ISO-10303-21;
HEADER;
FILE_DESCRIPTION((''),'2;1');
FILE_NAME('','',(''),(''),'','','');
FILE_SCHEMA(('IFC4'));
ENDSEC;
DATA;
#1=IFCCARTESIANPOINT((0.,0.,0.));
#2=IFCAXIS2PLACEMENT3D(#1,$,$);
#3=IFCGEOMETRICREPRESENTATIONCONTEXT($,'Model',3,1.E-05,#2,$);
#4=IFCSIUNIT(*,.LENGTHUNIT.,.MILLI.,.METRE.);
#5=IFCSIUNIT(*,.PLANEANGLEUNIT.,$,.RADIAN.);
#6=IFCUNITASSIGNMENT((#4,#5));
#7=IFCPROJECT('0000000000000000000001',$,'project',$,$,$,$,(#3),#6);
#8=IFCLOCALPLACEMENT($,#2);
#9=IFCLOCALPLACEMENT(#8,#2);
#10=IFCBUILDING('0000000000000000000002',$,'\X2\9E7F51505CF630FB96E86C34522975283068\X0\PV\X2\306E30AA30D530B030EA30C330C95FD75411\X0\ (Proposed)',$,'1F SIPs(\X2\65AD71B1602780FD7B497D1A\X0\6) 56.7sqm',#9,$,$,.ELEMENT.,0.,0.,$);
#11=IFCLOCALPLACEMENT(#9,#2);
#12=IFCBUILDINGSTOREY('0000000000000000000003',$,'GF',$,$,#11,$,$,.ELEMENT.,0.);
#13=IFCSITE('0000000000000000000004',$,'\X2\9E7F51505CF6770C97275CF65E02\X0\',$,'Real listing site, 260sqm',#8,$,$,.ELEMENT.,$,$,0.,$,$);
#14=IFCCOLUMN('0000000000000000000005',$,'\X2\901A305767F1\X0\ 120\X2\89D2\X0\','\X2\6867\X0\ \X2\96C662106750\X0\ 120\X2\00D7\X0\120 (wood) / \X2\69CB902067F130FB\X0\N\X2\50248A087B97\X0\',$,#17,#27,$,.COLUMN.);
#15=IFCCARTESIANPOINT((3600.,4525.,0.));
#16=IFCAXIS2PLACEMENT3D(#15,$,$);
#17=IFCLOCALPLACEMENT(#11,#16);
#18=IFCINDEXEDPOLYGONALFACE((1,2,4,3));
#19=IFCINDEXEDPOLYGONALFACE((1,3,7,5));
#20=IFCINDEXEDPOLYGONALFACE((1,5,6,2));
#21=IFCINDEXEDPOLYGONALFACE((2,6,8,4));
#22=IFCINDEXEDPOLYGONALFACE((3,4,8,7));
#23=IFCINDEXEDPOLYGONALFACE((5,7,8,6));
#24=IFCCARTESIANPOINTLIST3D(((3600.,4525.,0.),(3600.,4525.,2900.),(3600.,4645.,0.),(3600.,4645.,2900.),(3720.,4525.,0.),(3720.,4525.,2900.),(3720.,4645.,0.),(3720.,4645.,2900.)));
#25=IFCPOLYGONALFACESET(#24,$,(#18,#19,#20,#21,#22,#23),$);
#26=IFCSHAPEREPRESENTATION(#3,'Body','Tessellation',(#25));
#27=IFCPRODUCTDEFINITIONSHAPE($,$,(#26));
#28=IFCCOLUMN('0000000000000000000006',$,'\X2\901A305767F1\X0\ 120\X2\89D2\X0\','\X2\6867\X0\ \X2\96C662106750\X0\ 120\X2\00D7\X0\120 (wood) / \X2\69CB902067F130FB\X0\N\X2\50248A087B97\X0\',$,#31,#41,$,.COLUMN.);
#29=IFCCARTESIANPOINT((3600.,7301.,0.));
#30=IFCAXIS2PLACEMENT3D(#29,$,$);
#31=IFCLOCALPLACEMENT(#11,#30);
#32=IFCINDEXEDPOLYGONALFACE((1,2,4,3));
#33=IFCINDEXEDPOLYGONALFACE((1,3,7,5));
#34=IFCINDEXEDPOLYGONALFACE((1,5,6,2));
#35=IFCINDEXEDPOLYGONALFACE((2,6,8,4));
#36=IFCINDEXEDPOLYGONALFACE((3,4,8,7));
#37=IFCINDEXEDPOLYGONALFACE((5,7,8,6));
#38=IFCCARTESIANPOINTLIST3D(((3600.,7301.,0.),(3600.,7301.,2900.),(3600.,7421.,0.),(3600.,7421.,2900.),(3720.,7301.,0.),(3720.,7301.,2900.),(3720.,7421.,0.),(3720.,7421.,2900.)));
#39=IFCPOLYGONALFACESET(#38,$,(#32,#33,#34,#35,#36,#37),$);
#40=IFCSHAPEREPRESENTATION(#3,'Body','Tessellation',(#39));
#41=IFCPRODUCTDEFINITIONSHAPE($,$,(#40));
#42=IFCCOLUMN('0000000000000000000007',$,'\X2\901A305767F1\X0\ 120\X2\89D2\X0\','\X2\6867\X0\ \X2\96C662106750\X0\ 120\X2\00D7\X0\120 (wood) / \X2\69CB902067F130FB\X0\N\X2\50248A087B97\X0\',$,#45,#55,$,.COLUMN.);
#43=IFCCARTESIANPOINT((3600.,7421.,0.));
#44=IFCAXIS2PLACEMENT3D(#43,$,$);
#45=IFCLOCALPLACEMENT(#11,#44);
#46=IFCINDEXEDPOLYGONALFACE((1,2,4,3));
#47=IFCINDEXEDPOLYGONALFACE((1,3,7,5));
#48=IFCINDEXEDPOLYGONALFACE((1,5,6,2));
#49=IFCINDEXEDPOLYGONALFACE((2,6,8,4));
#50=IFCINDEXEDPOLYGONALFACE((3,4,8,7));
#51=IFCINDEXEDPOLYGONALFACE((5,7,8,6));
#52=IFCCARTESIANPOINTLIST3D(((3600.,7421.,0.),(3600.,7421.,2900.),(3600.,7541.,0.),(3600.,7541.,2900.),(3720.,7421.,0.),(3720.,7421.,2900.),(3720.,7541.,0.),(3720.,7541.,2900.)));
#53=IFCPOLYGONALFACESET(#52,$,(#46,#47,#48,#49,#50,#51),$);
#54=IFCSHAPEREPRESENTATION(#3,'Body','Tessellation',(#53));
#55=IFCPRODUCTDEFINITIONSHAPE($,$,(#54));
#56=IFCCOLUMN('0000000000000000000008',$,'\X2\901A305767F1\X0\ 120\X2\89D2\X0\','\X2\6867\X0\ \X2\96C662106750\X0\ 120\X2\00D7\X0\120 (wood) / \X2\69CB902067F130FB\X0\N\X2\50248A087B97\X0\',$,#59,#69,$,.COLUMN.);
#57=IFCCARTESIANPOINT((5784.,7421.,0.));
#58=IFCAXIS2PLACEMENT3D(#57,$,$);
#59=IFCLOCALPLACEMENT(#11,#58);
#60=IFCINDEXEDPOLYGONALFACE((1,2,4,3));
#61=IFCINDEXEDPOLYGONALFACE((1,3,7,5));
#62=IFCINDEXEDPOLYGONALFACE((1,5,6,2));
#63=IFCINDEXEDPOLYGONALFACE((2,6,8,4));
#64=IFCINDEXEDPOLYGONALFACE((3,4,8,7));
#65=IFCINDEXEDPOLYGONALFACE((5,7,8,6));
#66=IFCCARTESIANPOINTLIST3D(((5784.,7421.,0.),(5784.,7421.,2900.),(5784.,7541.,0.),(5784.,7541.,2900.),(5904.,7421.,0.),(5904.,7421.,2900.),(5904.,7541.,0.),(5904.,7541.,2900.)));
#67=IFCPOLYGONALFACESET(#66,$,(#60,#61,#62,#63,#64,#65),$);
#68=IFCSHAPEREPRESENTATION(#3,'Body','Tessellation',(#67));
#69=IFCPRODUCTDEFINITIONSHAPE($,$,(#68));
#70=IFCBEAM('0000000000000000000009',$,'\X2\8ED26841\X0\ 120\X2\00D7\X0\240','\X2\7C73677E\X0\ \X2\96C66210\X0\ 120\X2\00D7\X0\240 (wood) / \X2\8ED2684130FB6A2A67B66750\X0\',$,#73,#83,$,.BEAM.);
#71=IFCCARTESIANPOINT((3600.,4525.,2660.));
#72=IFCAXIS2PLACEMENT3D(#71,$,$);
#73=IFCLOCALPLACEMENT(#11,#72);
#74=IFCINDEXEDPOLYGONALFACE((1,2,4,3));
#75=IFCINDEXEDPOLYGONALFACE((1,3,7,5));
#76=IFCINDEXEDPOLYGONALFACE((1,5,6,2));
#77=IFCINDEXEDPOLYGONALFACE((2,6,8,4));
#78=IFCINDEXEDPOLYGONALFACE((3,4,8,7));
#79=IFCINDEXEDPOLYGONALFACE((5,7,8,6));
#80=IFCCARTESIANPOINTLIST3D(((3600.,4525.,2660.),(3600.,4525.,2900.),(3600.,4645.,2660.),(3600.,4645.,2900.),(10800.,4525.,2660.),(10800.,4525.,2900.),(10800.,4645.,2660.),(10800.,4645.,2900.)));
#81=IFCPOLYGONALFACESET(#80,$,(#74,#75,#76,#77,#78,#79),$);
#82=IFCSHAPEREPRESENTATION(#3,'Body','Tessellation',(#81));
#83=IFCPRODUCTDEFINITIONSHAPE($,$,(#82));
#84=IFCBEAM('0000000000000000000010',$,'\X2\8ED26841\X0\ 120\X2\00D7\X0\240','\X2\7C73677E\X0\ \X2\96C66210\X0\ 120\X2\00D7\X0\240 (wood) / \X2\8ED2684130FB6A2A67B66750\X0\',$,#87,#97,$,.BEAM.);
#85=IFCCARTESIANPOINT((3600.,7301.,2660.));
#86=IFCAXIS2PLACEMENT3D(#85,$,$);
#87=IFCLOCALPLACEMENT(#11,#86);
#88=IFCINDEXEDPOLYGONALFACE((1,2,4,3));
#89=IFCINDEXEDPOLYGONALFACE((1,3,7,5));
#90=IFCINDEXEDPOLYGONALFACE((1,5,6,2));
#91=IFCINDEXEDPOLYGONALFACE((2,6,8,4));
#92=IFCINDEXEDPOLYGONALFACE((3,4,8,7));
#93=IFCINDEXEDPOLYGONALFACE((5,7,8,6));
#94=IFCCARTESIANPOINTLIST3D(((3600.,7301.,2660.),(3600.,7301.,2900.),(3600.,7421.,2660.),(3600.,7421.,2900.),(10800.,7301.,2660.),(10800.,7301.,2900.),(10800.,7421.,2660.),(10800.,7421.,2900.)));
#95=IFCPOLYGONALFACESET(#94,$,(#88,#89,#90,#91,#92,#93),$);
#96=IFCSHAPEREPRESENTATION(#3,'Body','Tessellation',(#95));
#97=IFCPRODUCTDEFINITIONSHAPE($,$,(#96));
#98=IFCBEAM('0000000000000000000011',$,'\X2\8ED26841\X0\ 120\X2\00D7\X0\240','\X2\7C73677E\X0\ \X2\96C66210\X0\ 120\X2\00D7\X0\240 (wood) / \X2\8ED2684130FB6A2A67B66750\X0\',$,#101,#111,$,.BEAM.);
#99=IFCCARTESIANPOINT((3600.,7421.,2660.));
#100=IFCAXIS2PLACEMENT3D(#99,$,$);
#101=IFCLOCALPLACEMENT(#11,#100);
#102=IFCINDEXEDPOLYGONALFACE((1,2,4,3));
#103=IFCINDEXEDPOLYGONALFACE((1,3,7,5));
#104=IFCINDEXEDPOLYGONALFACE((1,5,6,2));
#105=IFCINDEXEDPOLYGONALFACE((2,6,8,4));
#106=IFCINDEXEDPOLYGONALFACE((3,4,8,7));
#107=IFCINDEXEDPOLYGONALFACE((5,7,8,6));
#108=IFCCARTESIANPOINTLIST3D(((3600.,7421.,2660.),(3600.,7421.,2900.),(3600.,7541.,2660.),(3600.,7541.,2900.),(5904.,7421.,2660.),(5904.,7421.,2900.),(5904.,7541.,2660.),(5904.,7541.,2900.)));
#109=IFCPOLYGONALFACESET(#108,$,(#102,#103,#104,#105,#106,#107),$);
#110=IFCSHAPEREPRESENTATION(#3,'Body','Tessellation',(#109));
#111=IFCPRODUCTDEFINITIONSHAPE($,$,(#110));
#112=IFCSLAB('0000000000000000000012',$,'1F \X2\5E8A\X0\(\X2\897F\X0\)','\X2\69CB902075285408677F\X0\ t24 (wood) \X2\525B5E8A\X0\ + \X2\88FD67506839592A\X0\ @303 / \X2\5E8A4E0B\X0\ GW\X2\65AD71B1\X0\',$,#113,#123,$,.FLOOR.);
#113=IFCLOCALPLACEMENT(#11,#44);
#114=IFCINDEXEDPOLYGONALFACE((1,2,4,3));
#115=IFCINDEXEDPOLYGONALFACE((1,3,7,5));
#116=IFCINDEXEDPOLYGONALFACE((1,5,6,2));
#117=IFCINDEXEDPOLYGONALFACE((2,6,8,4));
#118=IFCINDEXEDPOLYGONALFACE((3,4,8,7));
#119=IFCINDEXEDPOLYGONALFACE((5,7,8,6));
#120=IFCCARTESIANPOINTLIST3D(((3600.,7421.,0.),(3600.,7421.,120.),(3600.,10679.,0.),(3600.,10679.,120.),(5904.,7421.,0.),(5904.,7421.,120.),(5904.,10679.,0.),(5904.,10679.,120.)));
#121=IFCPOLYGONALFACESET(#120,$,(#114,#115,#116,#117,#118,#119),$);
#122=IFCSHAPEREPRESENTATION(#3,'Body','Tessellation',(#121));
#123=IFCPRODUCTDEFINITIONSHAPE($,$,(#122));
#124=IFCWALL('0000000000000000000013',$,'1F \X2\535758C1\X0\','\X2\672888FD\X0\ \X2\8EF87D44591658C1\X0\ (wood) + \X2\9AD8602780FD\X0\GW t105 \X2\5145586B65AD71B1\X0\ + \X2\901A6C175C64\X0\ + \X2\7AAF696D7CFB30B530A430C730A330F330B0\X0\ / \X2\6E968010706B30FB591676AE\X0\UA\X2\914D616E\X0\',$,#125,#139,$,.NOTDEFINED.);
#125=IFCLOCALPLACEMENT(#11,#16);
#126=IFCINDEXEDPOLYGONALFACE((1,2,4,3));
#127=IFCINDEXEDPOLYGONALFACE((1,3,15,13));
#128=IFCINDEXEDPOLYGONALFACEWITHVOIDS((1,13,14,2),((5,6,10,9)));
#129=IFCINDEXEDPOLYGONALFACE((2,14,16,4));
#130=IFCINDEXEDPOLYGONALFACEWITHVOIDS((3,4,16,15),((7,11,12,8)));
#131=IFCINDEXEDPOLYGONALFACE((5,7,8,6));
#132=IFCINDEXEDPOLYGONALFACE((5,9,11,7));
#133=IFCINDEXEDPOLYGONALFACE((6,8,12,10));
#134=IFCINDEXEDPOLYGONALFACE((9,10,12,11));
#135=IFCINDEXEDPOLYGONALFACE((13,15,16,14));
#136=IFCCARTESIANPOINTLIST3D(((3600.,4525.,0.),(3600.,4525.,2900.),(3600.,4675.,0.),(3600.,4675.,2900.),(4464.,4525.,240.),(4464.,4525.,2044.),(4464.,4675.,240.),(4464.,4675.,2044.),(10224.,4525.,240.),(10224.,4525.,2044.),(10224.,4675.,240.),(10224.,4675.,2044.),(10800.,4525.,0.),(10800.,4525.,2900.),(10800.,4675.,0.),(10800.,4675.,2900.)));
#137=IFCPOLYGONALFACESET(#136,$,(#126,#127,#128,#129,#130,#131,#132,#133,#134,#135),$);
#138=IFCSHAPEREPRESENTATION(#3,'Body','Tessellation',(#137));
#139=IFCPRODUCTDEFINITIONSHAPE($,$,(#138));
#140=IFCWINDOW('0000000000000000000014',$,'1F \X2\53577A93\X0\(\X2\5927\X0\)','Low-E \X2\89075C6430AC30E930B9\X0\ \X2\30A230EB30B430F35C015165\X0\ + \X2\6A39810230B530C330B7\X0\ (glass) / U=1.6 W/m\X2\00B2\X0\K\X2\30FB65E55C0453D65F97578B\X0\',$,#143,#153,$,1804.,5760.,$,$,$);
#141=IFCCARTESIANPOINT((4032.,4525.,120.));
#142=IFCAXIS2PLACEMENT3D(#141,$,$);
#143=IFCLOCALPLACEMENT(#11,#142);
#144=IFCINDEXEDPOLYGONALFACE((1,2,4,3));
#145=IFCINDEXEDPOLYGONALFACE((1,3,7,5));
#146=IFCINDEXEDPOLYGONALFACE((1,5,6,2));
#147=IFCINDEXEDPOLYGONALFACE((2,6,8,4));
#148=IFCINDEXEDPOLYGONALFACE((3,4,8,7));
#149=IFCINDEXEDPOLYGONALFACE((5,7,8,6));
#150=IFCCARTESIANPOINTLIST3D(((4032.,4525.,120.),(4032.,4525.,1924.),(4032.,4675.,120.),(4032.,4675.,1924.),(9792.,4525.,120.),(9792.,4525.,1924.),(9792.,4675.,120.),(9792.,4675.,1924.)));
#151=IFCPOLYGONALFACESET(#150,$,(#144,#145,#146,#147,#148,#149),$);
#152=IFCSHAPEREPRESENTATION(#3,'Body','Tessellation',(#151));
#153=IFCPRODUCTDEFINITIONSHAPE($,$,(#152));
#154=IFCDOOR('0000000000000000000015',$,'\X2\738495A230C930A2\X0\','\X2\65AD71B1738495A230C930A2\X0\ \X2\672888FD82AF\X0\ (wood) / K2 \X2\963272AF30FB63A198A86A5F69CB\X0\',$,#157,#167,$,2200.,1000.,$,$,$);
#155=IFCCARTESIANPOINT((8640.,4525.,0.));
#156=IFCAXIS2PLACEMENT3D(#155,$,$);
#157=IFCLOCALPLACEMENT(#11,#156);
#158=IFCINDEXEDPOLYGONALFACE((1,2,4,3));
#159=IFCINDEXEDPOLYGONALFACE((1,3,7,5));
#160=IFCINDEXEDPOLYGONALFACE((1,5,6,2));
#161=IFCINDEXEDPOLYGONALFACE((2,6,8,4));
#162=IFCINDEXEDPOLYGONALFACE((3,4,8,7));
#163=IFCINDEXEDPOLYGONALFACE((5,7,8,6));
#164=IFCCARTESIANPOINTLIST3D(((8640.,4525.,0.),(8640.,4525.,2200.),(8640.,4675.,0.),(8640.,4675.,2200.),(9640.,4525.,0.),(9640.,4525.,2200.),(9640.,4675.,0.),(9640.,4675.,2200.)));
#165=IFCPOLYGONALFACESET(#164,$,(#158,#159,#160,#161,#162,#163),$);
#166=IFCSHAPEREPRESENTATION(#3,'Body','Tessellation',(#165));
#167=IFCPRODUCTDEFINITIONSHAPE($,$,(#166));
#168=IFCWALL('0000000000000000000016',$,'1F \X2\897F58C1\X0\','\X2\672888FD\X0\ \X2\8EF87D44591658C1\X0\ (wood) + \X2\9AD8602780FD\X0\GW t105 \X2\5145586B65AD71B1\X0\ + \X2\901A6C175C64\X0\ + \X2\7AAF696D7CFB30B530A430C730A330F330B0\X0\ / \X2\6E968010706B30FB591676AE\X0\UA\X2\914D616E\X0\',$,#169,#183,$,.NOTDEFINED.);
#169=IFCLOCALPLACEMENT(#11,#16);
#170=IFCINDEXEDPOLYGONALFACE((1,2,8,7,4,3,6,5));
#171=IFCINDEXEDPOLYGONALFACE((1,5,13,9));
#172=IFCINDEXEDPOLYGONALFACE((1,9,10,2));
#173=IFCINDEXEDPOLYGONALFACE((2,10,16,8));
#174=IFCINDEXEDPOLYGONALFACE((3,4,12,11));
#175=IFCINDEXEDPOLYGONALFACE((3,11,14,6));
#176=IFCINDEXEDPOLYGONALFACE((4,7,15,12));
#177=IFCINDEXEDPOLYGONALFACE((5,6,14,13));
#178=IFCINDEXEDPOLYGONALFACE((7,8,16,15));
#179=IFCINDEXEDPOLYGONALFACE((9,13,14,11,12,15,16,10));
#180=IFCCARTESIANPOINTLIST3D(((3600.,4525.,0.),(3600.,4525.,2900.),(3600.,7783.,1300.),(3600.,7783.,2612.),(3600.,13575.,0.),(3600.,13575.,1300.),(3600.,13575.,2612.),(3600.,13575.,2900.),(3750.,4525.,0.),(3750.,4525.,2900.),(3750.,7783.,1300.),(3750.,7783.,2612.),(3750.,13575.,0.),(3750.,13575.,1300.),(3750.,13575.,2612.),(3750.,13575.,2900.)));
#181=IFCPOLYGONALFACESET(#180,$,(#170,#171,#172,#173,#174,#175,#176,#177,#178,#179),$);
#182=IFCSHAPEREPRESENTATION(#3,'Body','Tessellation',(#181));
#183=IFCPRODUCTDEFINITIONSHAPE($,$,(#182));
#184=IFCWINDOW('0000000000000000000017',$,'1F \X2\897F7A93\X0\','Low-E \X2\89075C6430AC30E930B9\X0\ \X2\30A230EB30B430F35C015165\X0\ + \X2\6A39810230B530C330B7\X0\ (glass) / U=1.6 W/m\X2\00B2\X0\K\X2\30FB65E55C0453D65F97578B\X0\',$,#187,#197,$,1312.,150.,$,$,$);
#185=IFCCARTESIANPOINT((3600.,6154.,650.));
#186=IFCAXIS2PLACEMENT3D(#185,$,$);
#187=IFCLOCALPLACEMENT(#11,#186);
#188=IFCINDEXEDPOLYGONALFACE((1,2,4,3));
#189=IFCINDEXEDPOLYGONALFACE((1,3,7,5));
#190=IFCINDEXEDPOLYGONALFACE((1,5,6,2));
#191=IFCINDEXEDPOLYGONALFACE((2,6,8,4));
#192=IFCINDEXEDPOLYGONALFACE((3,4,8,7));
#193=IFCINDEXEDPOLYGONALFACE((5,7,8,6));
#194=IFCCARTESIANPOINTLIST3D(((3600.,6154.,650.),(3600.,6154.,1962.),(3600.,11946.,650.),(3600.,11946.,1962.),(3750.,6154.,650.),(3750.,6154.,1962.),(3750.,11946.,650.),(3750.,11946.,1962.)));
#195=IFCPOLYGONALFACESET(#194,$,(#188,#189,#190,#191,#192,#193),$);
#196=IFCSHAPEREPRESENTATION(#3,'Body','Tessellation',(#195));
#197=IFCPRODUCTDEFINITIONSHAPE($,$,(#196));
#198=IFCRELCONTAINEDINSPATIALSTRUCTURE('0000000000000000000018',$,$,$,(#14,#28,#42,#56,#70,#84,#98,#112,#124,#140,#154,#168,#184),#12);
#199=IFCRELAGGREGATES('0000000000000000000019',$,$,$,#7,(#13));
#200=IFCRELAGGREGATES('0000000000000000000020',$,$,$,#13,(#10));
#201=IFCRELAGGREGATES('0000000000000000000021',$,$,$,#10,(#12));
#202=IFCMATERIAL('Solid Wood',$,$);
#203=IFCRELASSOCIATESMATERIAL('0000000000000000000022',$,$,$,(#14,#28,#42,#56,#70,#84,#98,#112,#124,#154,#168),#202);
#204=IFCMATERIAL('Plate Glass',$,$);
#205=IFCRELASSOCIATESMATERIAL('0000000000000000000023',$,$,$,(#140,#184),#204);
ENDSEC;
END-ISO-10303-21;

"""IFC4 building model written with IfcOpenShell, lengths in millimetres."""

from ifc_helpers import new_model, si_unit, frame, frame_2d, origin, place, context, project, spatial, rectangle, extrude, material, element, fill, save


model = new_model("IFC4")

# Units and contexts
model_context = context("Model", 3, precision=1e-05, world=origin())
ifc_project = project(units=[si_unit("LENGTHUNIT", "METRE", prefix="MILLI"), si_unit("PLANEANGLEUNIT", "RADIAN")], contexts=[model_context])

# Site, building, storey
site_placement = place(None, origin())
site = spatial("IfcSite", under=ifc_project, at=site_placement, Name="鹿児島県霧島市", ObjectType="Real listing site, 260sqm", CompositionType="ELEMENT", RefElevation=0.0)
building_placement = place(site_placement, origin())
building = spatial("IfcBuilding", under=site, at=building_placement, Name="鹿児島・雨水利用とPVのオフグリッド志向 (Proposed)", ObjectType="1F SIPs(断熱性能等級6) 56.7sqm", CompositionType="ELEMENT", ElevationOfRefHeight=0.0, ElevationOfTerrain=0.0)
storey_placement = place(building_placement, origin())
storey = spatial("IfcBuildingStorey", under=building, at=storey_placement, Name="GF", CompositionType="ELEMENT", Elevation=0.0)

# Columns
ifc_material_1 = material(Name="Solid Wood")
column_1_placement = place(storey_placement, frame((3600.0, 4525.0, 0.0)))
element("IfcColumn", 1, at=column_1_placement, inside=storey, material=ifc_material_1, Name="通し柱 120角", Description="桧 集成材 120×120 (wood) / 構造柱・N値計算", PredefinedType="COLUMN", context=model_context, shape_type="SweptSolid", body=[
    extrude(rectangle(XDim=120.0, YDim=120.0, at=frame_2d((60.0, 60.0))), frame((3600.0, 4525.0, 0.0)), (0.0, 0.0, 1.0), 2900.0),
])
column_2_placement = place(storey_placement, frame((3600.0, 7301.0, 0.0)))
element("IfcColumn", 2, at=column_2_placement, inside=storey, material=ifc_material_1, Name="通し柱 120角", Description="桧 集成材 120×120 (wood) / 構造柱・N値計算", PredefinedType="COLUMN", context=model_context, shape_type="SweptSolid", body=[
    extrude(rectangle(XDim=120.0, YDim=120.0, at=frame_2d((60.0, 60.0))), frame((3600.0, 7301.0, 0.0)), (0.0, 0.0, 1.0), 2900.0),
])
column_3_placement = place(storey_placement, frame((3600.0, 7421.0, 0.0)))
element("IfcColumn", 3, at=column_3_placement, inside=storey, material=ifc_material_1, Name="通し柱 120角", Description="桧 集成材 120×120 (wood) / 構造柱・N値計算", PredefinedType="COLUMN", context=model_context, shape_type="SweptSolid", body=[
    extrude(rectangle(XDim=120.0, YDim=120.0, at=frame_2d((60.0, 60.0))), frame((3600.0, 7421.0, 0.0)), (0.0, 0.0, 1.0), 2900.0),
])
column_4_placement = place(storey_placement, frame((5784.0, 7421.0, 0.0)))
element("IfcColumn", 4, at=column_4_placement, inside=storey, material=ifc_material_1, Name="通し柱 120角", Description="桧 集成材 120×120 (wood) / 構造柱・N値計算", PredefinedType="COLUMN", context=model_context, shape_type="SweptSolid", body=[
    extrude(rectangle(XDim=120.0, YDim=120.0, at=frame_2d((60.0, 60.0))), frame((5784.0, 7421.0, 0.0)), (0.0, 0.0, 1.0), 2900.0),
])

# Beams
beam_1_placement = place(storey_placement, frame((3600.0, 4525.0, 2660.0)))
element("IfcBeam", 5, at=beam_1_placement, inside=storey, material=ifc_material_1, Name="軒桁 120×240", Description="米松 集成 120×240 (wood) / 軒桁・横架材", PredefinedType="BEAM", context=model_context, shape_type="SweptSolid", body=[
    extrude(rectangle(XDim=7200.0, YDim=120.0, at=frame_2d((3600.0, 60.0))), frame((3600.0, 4525.0, 2660.0)), (0.0, 0.0, 1.0), 240.0),
])
beam_2_placement = place(storey_placement, frame((3600.0, 7301.0, 2660.0)))
element("IfcBeam", 6, at=beam_2_placement, inside=storey, material=ifc_material_1, Name="軒桁 120×240", Description="米松 集成 120×240 (wood) / 軒桁・横架材", PredefinedType="BEAM", context=model_context, shape_type="SweptSolid", body=[
    extrude(rectangle(XDim=7200.0, YDim=120.0, at=frame_2d((3600.0, 60.0))), frame((3600.0, 7301.0, 2660.0)), (0.0, 0.0, 1.0), 240.0),
])
beam_3_placement = place(storey_placement, frame((3600.0, 7421.0, 2660.0)))
element("IfcBeam", 7, at=beam_3_placement, inside=storey, material=ifc_material_1, Name="軒桁 120×240", Description="米松 集成 120×240 (wood) / 軒桁・横架材", PredefinedType="BEAM", context=model_context, shape_type="SweptSolid", body=[
    extrude(rectangle(XDim=2304.0, YDim=120.0, at=frame_2d((1152.0, 60.0))), frame((3600.0, 7421.0, 2660.0)), (0.0, 0.0, 1.0), 240.0),
])

# Slab
slab_1_placement = place(storey_placement, frame((3600.0, 7421.0, 0.0)))
element("IfcSlab", 8, at=slab_1_placement, inside=storey, material=ifc_material_1, Name="1F 床(西)", Description="構造用合板 t24 (wood) 剛床 + 製材根太 @303 / 床下 GW断熱", PredefinedType="FLOOR", context=model_context, shape_type="SweptSolid", body=[
    extrude(rectangle(XDim=2304.0, YDim=3258.0, at=frame_2d((1152.0, 1629.0))), frame((3600.0, 7421.0, 0.0)), (0.0, 0.0, 1.0), 120.0),
])

# Wall, openings, window, door
wall_1_placement = place(storey_placement, frame((3600.0, 4525.0, 0.0)))
wall_1 = element("IfcWall", 9, at=wall_1_placement, inside=storey, material=ifc_material_1, Name="1F 南壁", Description="木製 軸組外壁 (wood) + 高性能GW t105 充填断熱 + 通気層 + 窯業系サイディング / 準耐火・外皮UA配慮", PredefinedType="NOTDEFINED", context=model_context, shape_type="SweptSolid", body=[
    extrude(rectangle(XDim=7200.0, YDim=150.0, at=frame_2d((3600.0, 75.0))), frame((3600.0, 4525.0, 0.0)), (0.0, 0.0, 1.0), 2900.0),
])
opening_1_placement = place(storey_placement, frame((4032.0, 4525.0, 120.0)))
opening_1 = element("IfcOpeningElement", 10, at=opening_1_placement, cuts=wall_1, PredefinedType="NOTDEFINED", context=model_context, shape_type="SweptSolid", body=[
    extrude(rectangle(XDim=5760.0, YDim=150.0, at=frame_2d((2880.0, 75.0))), frame((4032.0, 4525.0, 120.0)), (0.0, 0.0, 1.0), 1804.0),
])
opening_2_placement = place(storey_placement, frame((8640.0, 4525.0, 0.0)))
opening_2 = element("IfcOpeningElement", 11, at=opening_2_placement, cuts=wall_1, PredefinedType="NOTDEFINED", context=model_context, shape_type="SweptSolid", body=[
    extrude(rectangle(XDim=1000.0, YDim=150.0, at=frame_2d((500.0, 75.0))), frame((8640.0, 4525.0, 0.0)), (0.0, 0.0, 1.0), 2200.0),
])
ifc_material_2 = material(Name="Plate Glass")
window_1_placement = place(storey_placement, frame((4032.0, 4525.0, 120.0)))
window_1 = element("IfcWindow", 12, at=window_1_placement, inside=storey, material=ifc_material_2, Name="1F 南窓(大)", Description="Low-E 複層ガラス アルゴン封入 + 樹脂サッシ (glass) / U=1.6 W/m²K・日射取得型", OverallHeight=1804.0, OverallWidth=5760.0, context=model_context, shape_type="SweptSolid", body=[
    extrude(rectangle(XDim=5760.0, YDim=150.0, at=frame_2d((2880.0, 75.0))), frame((4032.0, 4525.0, 120.0)), (0.0, 0.0, 1.0), 1804.0),
])
fill(opening_1, window_1)
door_placement = place(storey_placement, frame((8640.0, 4525.0, 0.0)))
door = element("IfcDoor", 13, at=door_placement, inside=storey, material=ifc_material_1, Name="玄関ドア", Description="断熱玄関ドア 木製芯 (wood) / K2 防犯・採風機構", OverallHeight=2200.0, OverallWidth=1000.0, context=model_context, shape_type="SweptSolid", body=[
    extrude(rectangle(XDim=1000.0, YDim=150.0, at=frame_2d((500.0, 75.0))), frame((8640.0, 4525.0, 0.0)), (0.0, 0.0, 1.0), 2200.0),
])
fill(opening_2, door)

# Wall, opening, window
wall_2_placement = place(storey_placement, frame((3600.0, 4525.0, 0.0)))
wall_2 = element("IfcWall", 14, at=wall_2_placement, inside=storey, material=ifc_material_1, Name="1F 西壁", Description="木製 軸組外壁 (wood) + 高性能GW t105 充填断熱 + 通気層 + 窯業系サイディング / 準耐火・外皮UA配慮", PredefinedType="NOTDEFINED", context=model_context, shape_type="SweptSolid", body=[
    extrude(rectangle(XDim=150.0, YDim=9050.0, at=frame_2d((75.0, 4525.0))), frame((3600.0, 4525.0, 0.0)), (0.0, 0.0, 1.0), 2900.0),
])
opening_3_placement = place(storey_placement, frame((3600.0, 6154.0, 650.0)))
opening_3 = element("IfcOpeningElement", 15, at=opening_3_placement, cuts=wall_2, PredefinedType="NOTDEFINED", context=model_context, shape_type="SweptSolid", body=[
    extrude(rectangle(XDim=150.0, YDim=5792.0, at=frame_2d((75.0, 2896.0))), frame((3600.0, 6154.0, 650.0)), (0.0, 0.0, 1.0), 1312.0),
])
window_2_placement = place(storey_placement, frame((3600.0, 6154.0, 650.0)))
window_2 = element("IfcWindow", 16, at=window_2_placement, inside=storey, material=ifc_material_2, Name="1F 西窓", Description="Low-E 複層ガラス アルゴン封入 + 樹脂サッシ (glass) / U=1.6 W/m²K・日射取得型", OverallHeight=1312.0, OverallWidth=150.0, context=model_context, shape_type="SweptSolid", body=[
    extrude(rectangle(XDim=150.0, YDim=5792.0, at=frame_2d((75.0, 2896.0))), frame((3600.0, 6154.0, 650.0)), (0.0, 0.0, 1.0), 1312.0),
])
fill(opening_3, window_2)

save(model, "model.ifc")
